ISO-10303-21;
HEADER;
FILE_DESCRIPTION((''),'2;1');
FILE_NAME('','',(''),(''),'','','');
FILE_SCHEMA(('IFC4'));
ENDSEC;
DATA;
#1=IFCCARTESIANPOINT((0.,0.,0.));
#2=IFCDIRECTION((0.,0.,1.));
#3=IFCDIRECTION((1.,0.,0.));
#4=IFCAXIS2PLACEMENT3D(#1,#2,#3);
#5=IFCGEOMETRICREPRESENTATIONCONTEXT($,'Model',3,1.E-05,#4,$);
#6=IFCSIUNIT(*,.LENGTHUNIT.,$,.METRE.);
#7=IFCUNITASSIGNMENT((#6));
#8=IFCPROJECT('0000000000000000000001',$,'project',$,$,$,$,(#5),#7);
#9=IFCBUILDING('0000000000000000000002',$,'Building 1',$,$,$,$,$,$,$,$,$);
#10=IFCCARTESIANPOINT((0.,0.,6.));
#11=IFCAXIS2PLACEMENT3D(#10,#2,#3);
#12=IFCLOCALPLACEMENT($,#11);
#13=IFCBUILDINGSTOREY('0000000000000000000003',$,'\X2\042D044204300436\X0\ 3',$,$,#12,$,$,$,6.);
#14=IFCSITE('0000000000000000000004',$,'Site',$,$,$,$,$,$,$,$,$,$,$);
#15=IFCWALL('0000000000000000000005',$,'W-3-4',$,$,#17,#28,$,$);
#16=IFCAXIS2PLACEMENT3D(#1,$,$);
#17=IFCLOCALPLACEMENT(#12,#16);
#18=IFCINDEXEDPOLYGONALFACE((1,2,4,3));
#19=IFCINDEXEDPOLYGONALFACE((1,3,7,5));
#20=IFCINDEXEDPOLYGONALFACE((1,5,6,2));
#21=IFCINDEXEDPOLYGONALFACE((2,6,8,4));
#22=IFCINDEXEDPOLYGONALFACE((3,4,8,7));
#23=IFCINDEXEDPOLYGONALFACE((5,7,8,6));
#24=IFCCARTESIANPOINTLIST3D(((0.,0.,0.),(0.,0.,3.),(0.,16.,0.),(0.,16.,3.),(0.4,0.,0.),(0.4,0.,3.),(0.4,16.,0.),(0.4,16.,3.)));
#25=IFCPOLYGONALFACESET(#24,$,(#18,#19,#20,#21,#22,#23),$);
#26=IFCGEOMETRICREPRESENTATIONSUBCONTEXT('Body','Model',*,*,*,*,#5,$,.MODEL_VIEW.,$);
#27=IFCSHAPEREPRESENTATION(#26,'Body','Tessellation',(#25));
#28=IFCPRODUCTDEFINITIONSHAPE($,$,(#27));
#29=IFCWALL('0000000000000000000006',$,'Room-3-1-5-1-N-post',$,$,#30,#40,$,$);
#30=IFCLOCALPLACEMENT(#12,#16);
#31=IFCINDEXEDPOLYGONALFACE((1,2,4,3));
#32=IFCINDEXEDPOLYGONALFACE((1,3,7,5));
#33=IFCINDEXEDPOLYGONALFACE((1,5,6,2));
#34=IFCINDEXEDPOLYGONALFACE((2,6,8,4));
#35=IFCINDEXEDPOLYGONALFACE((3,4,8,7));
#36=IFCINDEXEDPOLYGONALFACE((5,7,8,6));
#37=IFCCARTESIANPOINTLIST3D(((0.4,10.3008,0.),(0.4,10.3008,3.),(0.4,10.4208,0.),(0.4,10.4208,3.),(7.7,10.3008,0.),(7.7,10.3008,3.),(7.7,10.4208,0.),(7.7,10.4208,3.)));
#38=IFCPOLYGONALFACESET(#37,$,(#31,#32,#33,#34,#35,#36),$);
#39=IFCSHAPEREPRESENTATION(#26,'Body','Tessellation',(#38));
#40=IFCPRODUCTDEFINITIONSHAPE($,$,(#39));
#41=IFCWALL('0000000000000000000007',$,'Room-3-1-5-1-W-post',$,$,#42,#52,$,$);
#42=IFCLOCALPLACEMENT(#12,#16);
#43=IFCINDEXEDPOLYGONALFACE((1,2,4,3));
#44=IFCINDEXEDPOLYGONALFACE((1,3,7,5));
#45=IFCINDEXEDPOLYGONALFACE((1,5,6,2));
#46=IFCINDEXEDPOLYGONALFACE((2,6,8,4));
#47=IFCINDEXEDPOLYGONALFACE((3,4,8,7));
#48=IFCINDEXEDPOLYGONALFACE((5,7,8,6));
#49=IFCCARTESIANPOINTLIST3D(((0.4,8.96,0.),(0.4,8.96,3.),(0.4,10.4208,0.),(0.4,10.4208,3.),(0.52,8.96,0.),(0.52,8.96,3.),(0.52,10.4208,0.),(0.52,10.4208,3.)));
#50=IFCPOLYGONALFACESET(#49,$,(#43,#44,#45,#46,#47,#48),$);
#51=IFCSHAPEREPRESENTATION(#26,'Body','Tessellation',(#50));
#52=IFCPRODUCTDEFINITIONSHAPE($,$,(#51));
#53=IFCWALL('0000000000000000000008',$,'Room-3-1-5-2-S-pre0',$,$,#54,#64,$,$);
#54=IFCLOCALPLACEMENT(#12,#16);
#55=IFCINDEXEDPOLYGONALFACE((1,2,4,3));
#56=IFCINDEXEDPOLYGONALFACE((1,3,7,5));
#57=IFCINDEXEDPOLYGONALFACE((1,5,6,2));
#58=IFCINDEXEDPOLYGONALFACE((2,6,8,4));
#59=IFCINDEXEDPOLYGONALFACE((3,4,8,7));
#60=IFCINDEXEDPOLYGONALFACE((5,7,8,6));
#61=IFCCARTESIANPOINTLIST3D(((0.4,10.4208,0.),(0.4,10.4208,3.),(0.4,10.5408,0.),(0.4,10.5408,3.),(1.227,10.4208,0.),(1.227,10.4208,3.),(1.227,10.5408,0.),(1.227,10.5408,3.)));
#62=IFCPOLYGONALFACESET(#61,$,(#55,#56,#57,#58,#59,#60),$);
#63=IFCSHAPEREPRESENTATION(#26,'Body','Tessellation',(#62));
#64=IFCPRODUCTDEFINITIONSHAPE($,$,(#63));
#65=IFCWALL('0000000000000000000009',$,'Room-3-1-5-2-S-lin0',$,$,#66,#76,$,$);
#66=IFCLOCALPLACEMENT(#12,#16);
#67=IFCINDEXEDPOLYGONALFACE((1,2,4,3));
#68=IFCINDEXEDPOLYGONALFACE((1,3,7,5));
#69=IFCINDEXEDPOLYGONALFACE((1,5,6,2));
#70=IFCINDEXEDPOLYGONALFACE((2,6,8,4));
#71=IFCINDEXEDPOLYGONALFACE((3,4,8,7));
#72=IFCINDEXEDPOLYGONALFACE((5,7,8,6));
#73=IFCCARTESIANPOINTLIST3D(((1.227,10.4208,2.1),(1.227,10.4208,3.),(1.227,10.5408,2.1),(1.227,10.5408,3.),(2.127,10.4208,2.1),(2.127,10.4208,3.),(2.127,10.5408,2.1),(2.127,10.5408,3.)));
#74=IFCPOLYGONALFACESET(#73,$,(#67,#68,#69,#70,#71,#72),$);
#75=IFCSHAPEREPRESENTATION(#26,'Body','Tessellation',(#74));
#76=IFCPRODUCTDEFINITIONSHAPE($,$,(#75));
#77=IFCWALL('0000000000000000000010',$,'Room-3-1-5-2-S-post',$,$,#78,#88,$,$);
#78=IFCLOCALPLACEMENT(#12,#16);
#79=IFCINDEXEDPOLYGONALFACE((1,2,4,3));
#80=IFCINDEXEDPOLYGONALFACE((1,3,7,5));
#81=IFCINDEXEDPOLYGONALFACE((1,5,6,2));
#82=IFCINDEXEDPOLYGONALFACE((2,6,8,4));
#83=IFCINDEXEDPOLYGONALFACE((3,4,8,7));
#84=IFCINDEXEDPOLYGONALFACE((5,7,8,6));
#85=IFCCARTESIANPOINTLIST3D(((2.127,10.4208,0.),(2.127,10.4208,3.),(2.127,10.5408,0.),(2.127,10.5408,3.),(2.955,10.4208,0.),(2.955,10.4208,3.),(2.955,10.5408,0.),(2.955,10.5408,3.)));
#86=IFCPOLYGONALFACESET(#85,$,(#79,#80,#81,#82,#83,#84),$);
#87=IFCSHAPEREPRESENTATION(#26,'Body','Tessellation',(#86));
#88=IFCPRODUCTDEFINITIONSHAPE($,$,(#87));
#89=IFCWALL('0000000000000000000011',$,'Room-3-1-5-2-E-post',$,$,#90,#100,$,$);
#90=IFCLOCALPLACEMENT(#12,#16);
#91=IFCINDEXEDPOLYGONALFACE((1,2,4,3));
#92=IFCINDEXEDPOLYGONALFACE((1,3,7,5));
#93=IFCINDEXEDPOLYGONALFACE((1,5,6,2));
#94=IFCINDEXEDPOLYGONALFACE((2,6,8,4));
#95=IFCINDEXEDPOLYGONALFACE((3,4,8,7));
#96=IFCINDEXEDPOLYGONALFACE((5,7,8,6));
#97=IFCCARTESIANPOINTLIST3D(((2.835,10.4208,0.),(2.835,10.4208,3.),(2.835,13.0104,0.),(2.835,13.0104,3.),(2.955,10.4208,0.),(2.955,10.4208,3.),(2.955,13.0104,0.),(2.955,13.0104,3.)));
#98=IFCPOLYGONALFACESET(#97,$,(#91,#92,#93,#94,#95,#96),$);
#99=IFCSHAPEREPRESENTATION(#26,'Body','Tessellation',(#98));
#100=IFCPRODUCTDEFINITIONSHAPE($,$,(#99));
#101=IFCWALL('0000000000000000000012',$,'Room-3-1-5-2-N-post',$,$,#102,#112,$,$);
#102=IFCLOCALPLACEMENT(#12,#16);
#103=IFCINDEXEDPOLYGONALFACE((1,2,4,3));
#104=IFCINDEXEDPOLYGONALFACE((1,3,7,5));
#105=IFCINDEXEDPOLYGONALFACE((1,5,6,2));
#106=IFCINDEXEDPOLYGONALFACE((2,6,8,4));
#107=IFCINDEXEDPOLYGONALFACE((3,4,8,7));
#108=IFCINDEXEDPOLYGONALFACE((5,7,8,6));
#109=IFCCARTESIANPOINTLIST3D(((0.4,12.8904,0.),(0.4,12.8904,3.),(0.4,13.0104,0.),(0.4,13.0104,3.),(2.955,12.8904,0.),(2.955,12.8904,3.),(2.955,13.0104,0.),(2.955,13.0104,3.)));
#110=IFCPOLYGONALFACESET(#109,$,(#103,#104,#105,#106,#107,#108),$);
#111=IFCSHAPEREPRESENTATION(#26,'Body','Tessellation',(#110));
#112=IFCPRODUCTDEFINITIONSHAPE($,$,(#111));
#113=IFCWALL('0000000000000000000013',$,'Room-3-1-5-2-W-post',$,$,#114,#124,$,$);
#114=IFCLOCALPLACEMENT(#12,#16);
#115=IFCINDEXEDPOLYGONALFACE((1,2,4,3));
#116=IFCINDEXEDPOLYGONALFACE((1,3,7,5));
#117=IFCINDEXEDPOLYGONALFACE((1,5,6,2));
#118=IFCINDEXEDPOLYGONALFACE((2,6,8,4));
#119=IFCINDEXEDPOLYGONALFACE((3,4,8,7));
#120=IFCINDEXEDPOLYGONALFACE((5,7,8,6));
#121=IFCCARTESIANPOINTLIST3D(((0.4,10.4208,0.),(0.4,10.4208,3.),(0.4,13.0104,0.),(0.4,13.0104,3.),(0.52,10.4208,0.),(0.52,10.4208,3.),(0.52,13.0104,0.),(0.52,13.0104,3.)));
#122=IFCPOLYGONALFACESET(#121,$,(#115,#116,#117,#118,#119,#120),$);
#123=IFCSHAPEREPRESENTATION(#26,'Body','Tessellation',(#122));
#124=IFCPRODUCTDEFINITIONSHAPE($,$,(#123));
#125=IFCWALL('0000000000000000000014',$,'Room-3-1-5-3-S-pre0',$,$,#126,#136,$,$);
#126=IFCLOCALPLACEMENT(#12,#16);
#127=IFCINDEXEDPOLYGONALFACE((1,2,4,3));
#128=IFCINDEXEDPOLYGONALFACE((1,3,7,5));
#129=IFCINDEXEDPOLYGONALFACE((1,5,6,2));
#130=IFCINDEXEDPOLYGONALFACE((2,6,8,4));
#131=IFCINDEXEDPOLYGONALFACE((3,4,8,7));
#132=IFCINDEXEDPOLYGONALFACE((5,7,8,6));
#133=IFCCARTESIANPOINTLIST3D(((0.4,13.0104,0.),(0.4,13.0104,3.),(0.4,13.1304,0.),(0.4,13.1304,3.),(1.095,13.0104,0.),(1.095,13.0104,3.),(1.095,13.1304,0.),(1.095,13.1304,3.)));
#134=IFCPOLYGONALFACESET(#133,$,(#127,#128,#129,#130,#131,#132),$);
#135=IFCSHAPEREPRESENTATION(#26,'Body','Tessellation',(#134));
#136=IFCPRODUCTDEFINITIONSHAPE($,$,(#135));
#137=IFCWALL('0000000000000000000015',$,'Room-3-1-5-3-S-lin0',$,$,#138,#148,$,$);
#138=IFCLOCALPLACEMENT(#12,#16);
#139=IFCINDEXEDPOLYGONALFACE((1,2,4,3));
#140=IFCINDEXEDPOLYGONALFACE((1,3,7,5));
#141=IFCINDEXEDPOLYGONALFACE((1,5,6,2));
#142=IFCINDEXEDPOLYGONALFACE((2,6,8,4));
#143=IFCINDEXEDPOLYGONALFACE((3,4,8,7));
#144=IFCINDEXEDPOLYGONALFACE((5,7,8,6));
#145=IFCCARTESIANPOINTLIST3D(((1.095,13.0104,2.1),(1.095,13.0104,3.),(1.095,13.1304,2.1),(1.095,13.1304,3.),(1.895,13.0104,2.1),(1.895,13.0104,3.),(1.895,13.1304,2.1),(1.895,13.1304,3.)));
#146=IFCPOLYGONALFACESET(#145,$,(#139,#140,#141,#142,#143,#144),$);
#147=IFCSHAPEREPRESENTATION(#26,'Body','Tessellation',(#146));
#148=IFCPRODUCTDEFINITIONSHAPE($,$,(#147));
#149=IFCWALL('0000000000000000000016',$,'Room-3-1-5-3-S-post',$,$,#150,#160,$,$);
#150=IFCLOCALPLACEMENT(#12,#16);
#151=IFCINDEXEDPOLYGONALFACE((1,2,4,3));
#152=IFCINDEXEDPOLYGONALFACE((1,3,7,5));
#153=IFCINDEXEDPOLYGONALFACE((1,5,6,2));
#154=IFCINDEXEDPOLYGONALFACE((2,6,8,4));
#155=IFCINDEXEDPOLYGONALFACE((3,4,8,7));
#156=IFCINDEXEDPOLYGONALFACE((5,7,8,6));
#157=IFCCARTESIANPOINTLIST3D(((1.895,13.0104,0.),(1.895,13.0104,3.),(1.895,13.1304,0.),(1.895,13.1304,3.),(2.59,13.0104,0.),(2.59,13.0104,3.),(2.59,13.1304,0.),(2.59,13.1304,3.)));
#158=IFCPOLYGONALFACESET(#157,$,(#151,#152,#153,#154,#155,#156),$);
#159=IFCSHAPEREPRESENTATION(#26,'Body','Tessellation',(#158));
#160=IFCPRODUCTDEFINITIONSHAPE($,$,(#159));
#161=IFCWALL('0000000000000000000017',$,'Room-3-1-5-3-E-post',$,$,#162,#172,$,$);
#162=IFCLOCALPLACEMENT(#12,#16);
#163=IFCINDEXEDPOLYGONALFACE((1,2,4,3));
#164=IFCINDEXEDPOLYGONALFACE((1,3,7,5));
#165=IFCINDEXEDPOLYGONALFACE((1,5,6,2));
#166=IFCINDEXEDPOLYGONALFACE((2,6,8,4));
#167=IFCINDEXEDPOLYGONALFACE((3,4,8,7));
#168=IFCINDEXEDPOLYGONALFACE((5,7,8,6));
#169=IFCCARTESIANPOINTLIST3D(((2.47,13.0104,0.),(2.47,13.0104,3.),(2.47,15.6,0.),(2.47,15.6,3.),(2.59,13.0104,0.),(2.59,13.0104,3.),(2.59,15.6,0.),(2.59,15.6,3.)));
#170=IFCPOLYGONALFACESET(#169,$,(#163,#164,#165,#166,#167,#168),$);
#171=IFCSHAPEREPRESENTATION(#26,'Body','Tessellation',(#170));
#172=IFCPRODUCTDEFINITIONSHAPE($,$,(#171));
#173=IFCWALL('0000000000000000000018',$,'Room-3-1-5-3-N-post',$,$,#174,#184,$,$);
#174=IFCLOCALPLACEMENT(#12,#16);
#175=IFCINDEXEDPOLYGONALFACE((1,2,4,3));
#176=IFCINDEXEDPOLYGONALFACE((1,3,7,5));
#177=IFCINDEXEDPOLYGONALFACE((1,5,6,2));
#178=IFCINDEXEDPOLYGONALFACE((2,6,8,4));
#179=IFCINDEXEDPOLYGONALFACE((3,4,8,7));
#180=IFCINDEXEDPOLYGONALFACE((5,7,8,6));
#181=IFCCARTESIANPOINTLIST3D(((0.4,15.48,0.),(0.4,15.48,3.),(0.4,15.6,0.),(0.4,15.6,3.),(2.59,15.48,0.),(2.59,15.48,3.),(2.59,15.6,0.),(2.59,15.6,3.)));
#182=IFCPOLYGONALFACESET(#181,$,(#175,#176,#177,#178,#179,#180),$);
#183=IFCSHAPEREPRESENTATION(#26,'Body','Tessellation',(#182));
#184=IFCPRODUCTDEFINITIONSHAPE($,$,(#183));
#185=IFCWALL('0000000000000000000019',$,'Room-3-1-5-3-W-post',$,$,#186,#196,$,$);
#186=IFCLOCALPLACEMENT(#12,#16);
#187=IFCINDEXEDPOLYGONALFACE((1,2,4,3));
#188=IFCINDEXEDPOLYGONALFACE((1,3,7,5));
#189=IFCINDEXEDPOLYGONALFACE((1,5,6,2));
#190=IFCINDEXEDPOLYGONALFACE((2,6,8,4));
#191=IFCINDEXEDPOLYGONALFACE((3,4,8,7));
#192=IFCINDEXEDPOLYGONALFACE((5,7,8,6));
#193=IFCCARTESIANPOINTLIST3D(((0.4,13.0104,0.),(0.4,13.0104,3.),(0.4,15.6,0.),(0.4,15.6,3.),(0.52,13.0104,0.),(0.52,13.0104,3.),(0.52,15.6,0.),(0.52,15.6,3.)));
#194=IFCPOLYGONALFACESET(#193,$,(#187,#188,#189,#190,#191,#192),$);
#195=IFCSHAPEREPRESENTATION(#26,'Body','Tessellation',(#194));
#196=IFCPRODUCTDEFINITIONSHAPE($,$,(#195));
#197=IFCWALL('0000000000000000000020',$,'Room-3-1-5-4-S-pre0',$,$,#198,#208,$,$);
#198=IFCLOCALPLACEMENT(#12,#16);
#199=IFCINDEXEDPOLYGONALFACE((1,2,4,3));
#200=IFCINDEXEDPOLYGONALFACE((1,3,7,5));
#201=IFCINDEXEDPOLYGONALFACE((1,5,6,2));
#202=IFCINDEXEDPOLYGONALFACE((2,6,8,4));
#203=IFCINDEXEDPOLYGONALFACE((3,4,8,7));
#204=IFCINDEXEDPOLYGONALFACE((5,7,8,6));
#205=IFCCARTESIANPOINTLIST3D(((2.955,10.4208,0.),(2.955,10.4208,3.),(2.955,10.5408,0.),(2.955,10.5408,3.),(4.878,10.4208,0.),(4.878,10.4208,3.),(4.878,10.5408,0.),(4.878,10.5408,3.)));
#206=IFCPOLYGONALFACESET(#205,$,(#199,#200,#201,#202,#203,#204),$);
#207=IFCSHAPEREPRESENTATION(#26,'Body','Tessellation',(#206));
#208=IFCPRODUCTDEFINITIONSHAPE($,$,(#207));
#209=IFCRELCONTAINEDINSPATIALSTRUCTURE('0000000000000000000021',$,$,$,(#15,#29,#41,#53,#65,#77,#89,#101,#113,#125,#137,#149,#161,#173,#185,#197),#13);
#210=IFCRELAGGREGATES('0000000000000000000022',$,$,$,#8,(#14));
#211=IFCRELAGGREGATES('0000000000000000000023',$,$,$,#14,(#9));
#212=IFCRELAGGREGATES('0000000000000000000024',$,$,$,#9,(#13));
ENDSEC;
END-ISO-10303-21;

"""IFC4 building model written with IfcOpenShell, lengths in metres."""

from ifc_helpers import new_model, si_unit, frame, origin_with_axes, place, context, subcontext, project, spatial, indexed_curve, outline, extrude, element, save


model = new_model("IFC4")

# Units and contexts
model_context = context("Model", 3, precision=1e-05, world=origin_with_axes())
body_context = subcontext(model_context, "Body", "Model", "MODEL_VIEW")
ifc_project = project(units=[si_unit("LENGTHUNIT", "METRE")], contexts=[model_context])

# Site, building, storey
site = spatial("IfcSite", under=ifc_project, Name="Site")
building = spatial("IfcBuilding", under=site, Name="Building 1")
storey_placement = place(None, frame((0.0, 0.0, 6.0), z_axis=(0.0, 0.0, 1.0), x_axis=(1.0, 0.0, 0.0)))
storey = spatial("IfcBuildingStorey", under=building, at=storey_placement, Name="Этаж 3", Elevation=6.0)

# Walls
wall_1_placement = place(storey_placement, frame((0.0, 16.0, 0.0), z_axis=(0.0, 0.0, 1.0), x_axis=(0.0, -1.0, 0.0)))
element("IfcWall", 1, at=wall_1_placement, inside=storey, Name="W-3-4", context=body_context, shape_type="SweptSolid", body=[
    extrude(outline(indexed_curve([(0.0, 0.0), (0.0, 0.4), (16.0, 0.4), (16.0, 0.0), (0.0, 0.0)], self_intersect=False)), origin_with_axes(), (0.0, 0.0, 1.0), 3.0),
])
wall_2_placement = place(storey_placement, frame((7.7, 10.4208, 0.0), z_axis=(0.0, 0.0, 1.0), x_axis=(-1.0, 0.0, 0.0)))
element("IfcWall", 2, at=wall_2_placement, inside=storey, Name="Room-3-1-5-1-N-post", context=body_context, shape_type="SweptSolid", body=[
    extrude(outline(indexed_curve([(0.0, 0.0), (0.0, 0.12), (7.3, 0.12), (7.3, 0.0), (0.0, 0.0)], self_intersect=False)), origin_with_axes(), (0.0, 0.0, 1.0), 3.0),
])
wall_3_placement = place(storey_placement, frame((0.4, 10.4208, 0.0), z_axis=(0.0, 0.0, 1.0), x_axis=(0.0, -1.0, 0.0)))
element("IfcWall", 3, at=wall_3_placement, inside=storey, Name="Room-3-1-5-1-W-post", context=body_context, shape_type="SweptSolid", body=[
    extrude(outline(indexed_curve([(0.0, 0.0), (0.0, 0.12), (1.4608, 0.12), (1.4608, 0.0), (0.0, 0.0)], self_intersect=False)), origin_with_axes(), (0.0, 0.0, 1.0), 3.0),
])
wall_4_placement = place(storey_placement, frame((0.4, 10.4208, 0.0), z_axis=(0.0, 0.0, 1.0), x_axis=(1.0, 0.0, 0.0)))
element("IfcWall", 4, at=wall_4_placement, inside=storey, Name="Room-3-1-5-2-S-pre0", context=body_context, shape_type="SweptSolid", body=[
    extrude(outline(indexed_curve([(0.0, 0.0), (0.0, 0.12), (0.827, 0.12), (0.827, 0.0), (0.0, 0.0)], self_intersect=False)), origin_with_axes(), (0.0, 0.0, 1.0), 3.0),
])
wall_5_placement = place(storey_placement, frame((1.227, 10.4208, 2.1), z_axis=(0.0, 0.0, 1.0), x_axis=(1.0, 0.0, 0.0)))
element("IfcWall", 5, at=wall_5_placement, inside=storey, Name="Room-3-1-5-2-S-lin0", context=body_context, shape_type="SweptSolid", body=[
    extrude(outline(indexed_curve([(0.0, 0.0), (0.0, 0.12), (0.9, 0.12), (0.9, 0.0), (0.0, 0.0)], self_intersect=False)), origin_with_axes(), (0.0, 0.0, 1.0), 0.9),
])
wall_6_placement = place(storey_placement, frame((2.127, 10.4208, 0.0), z_axis=(0.0, 0.0, 1.0), x_axis=(1.0, 0.0, 0.0)))
element("IfcWall", 6, at=wall_6_placement, inside=storey, Name="Room-3-1-5-2-S-post", context=body_context, shape_type="SweptSolid", body=[
    extrude(outline(indexed_curve([(0.0, 0.0), (0.0, 0.12), (0.828, 0.12), (0.828, 0.0), (0.0, 0.0)], self_intersect=False)), origin_with_axes(), (0.0, 0.0, 1.0), 3.0),
])
wall_7_placement = place(storey_placement, frame((2.955, 10.4208, 0.0), z_axis=(0.0, 0.0, 1.0), x_axis=(0.0, 1.0, 0.0)))
element("IfcWall", 7, at=wall_7_placement, inside=storey, Name="Room-3-1-5-2-E-post", context=body_context, shape_type="SweptSolid", body=[
    extrude(outline(indexed_curve([(0.0, 0.0), (0.0, 0.12), (2.5896, 0.12), (2.5896, 0.0), (0.0, 0.0)], self_intersect=False)), origin_with_axes(), (0.0, 0.0, 1.0), 3.0),
])
wall_8_placement = place(storey_placement, frame((2.955, 13.0104, 0.0), z_axis=(0.0, 0.0, 1.0), x_axis=(-1.0, 0.0, 0.0)))
element("IfcWall", 8, at=wall_8_placement, inside=storey, Name="Room-3-1-5-2-N-post", context=body_context, shape_type="SweptSolid", body=[
    extrude(outline(indexed_curve([(0.0, 0.0), (0.0, 0.12), (2.555, 0.12), (2.555, 0.0), (0.0, 0.0)], self_intersect=False)), origin_with_axes(), (0.0, 0.0, 1.0), 3.0),
])
wall_9_placement = place(storey_placement, frame((0.4, 13.0104, 0.0), z_axis=(0.0, 0.0, 1.0), x_axis=(0.0, -1.0, 0.0)))
element("IfcWall", 9, at=wall_9_placement, inside=storey, Name="Room-3-1-5-2-W-post", context=body_context, shape_type="SweptSolid", body=[
    extrude(outline(indexed_curve([(0.0, 0.0), (0.0, 0.12), (2.5896, 0.12), (2.5896, 0.0), (0.0, 0.0)], self_intersect=False)), origin_with_axes(), (0.0, 0.0, 1.0), 3.0),
])
wall_10_placement = place(storey_placement, frame((0.4, 13.0104, 0.0), z_axis=(0.0, 0.0, 1.0), x_axis=(1.0, 0.0, 0.0)))
element("IfcWall", 10, at=wall_10_placement, inside=storey, Name="Room-3-1-5-3-S-pre0", context=body_context, shape_type="SweptSolid", body=[
    extrude(outline(indexed_curve([(0.0, 0.0), (0.0, 0.12), (0.695, 0.12), (0.695, 0.0), (0.0, 0.0)], self_intersect=False)), origin_with_axes(), (0.0, 0.0, 1.0), 3.0),
])
wall_11_placement = place(storey_placement, frame((1.095, 13.0104, 2.1), z_axis=(0.0, 0.0, 1.0), x_axis=(1.0, 0.0, 0.0)))
element("IfcWall", 11, at=wall_11_placement, inside=storey, Name="Room-3-1-5-3-S-lin0", context=body_context, shape_type="SweptSolid", body=[
    extrude(outline(indexed_curve([(0.0, 0.0), (0.0, 0.12), (0.8, 0.12), (0.8, 0.0), (0.0, 0.0)], self_intersect=False)), origin_with_axes(), (0.0, 0.0, 1.0), 0.9),
])
wall_12_placement = place(storey_placement, frame((1.895, 13.0104, 0.0), z_axis=(0.0, 0.0, 1.0), x_axis=(1.0, 0.0, 0.0)))
element("IfcWall", 12, at=wall_12_placement, inside=storey, Name="Room-3-1-5-3-S-post", context=body_context, shape_type="SweptSolid", body=[
    extrude(outline(indexed_curve([(0.0, 0.0), (0.0, 0.12), (0.695, 0.12), (0.695, 0.0), (0.0, 0.0)], self_intersect=False)), origin_with_axes(), (0.0, 0.0, 1.0), 3.0),
])
wall_13_placement = place(storey_placement, frame((2.59, 13.0104, 0.0), z_axis=(0.0, 0.0, 1.0), x_axis=(0.0, 1.0, 0.0)))
element("IfcWall", 13, at=wall_13_placement, inside=storey, Name="Room-3-1-5-3-E-post", context=body_context, shape_type="SweptSolid", body=[
    extrude(outline(indexed_curve([(0.0, 0.0), (0.0, 0.12), (2.5896, 0.12), (2.5896, 0.0), (0.0, 0.0)], self_intersect=False)), origin_with_axes(), (0.0, 0.0, 1.0), 3.0),
])
wall_14_placement = place(storey_placement, frame((2.59, 15.6, 0.0), z_axis=(0.0, 0.0, 1.0), x_axis=(-1.0, 0.0, 0.0)))
element("IfcWall", 14, at=wall_14_placement, inside=storey, Name="Room-3-1-5-3-N-post", context=body_context, shape_type="SweptSolid", body=[
    extrude(outline(indexed_curve([(0.0, 0.0), (0.0, 0.12), (2.19, 0.12), (2.19, 0.0), (0.0, 0.0)], self_intersect=False)), origin_with_axes(), (0.0, 0.0, 1.0), 3.0),
])
wall_15_placement = place(storey_placement, frame((0.4, 15.6, 0.0), z_axis=(0.0, 0.0, 1.0), x_axis=(0.0, -1.0, 0.0)))
element("IfcWall", 15, at=wall_15_placement, inside=storey, Name="Room-3-1-5-3-W-post", context=body_context, shape_type="SweptSolid", body=[
    extrude(outline(indexed_curve([(0.0, 0.0), (0.0, 0.12), (2.5896, 0.12), (2.5896, 0.0), (0.0, 0.0)], self_intersect=False)), origin_with_axes(), (0.0, 0.0, 1.0), 3.0),
])
wall_16_placement = place(storey_placement, frame((2.955, 10.4208, 0.0), z_axis=(0.0, 0.0, 1.0), x_axis=(1.0, 0.0, 0.0)))
element("IfcWall", 16, at=wall_16_placement, inside=storey, Name="Room-3-1-5-4-S-pre0", context=body_context, shape_type="SweptSolid", body=[
    extrude(outline(indexed_curve([(0.0, 0.0), (0.0, 0.12), (1.923, 0.12), (1.923, 0.0), (0.0, 0.0)], self_intersect=False)), origin_with_axes(), (0.0, 0.0, 1.0), 3.0),
])

save(model, "model.ifc")
